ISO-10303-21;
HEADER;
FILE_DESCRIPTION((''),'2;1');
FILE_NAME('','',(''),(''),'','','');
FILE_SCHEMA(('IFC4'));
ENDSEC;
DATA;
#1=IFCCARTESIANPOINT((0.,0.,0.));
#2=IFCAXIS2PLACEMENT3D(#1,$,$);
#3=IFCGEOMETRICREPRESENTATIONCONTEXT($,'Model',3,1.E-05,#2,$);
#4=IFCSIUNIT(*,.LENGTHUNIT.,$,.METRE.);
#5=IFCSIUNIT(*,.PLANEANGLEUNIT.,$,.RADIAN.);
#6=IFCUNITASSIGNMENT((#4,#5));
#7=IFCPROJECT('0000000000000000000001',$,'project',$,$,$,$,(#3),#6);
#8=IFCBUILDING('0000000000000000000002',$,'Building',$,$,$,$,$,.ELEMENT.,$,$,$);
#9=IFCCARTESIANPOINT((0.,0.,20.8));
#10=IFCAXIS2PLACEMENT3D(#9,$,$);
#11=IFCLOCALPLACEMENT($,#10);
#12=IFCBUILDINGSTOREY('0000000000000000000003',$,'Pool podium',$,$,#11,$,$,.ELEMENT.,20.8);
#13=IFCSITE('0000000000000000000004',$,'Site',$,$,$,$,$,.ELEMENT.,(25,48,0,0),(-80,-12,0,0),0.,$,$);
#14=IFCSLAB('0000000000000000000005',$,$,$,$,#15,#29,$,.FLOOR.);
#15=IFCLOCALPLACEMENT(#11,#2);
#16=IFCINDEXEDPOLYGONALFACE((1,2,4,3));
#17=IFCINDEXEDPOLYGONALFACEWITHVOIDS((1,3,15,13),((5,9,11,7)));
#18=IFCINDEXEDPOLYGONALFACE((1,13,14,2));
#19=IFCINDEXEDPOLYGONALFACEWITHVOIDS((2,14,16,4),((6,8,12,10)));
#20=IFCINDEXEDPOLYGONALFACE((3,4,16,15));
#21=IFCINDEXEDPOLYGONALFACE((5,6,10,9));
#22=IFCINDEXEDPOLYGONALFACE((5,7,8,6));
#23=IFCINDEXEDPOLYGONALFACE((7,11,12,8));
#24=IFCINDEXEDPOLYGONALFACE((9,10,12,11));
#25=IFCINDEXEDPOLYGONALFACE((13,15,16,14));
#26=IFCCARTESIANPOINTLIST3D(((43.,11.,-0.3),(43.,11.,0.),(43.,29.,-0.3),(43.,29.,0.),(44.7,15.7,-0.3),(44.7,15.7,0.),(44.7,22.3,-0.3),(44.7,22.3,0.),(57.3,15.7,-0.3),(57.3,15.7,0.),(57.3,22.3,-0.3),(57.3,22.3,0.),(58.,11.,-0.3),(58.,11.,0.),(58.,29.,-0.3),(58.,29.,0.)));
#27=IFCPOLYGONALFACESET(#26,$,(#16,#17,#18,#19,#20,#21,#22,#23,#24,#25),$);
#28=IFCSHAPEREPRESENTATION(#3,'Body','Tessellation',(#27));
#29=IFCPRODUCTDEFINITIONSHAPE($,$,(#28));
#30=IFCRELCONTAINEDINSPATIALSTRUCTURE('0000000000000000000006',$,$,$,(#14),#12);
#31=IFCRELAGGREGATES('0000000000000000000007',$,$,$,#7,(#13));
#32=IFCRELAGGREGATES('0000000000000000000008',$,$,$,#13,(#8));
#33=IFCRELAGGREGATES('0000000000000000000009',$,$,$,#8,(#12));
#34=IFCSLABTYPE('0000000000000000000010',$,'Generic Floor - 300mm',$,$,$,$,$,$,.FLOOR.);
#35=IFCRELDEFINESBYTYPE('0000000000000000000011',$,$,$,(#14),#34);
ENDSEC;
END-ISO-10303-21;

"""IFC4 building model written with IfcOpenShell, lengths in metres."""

from ifc_helpers import new_model, si_unit, frame, origin, place, context, project, spatial, polyline, outline, extrude, type_object, element, save


model = new_model("IFC4")

# Units and contexts
model_context = context("Model", 3, precision=1e-05, world=origin())
ifc_project = project(units=[si_unit("LENGTHUNIT", "METRE"), si_unit("PLANEANGLEUNIT", "RADIAN")], contexts=[model_context])

# Site, building, storey
site = spatial("IfcSite", under=ifc_project, Name="Site", CompositionType="ELEMENT", RefLatitude=(25, 48, 0, 0), RefLongitude=(-80, -12, 0, 0), RefElevation=0.0)
building = spatial("IfcBuilding", under=site, Name="Building", CompositionType="ELEMENT")
storey_placement = place(None, frame((0.0, 0.0, 20.8)))
storey = spatial("IfcBuildingStorey", under=building, at=storey_placement, Name="Pool podium", CompositionType="ELEMENT", Elevation=20.8)

# Slab, opening
slab_type = type_object("IfcSlabType", Name="Generic Floor - 300mm", PredefinedType="FLOOR")
slab_placement = place(None, frame((0.0, 0.0, 20.8)))
slab = element("IfcSlab", 1, at=slab_placement, inside=storey, type_object=slab_type, PredefinedType="FLOOR", context=model_context, shape_type="SweptSolid", body=[
    extrude(outline(polyline([(43.0, 11.0), (58.0, 11.0), (58.0, 29.0), (43.0, 29.0), (43.0, 11.0)])), origin(), (0.0, 0.0, -1.0), 0.3),
])
opening_placement = place(None, frame((0.0, 0.0, 20.801)))
element("IfcOpeningElement", 2, at=opening_placement, cuts=slab, PredefinedType="OPENING", context=model_context, shape_type="SweptSolid", body=[
    extrude(outline(polyline([(44.7, 22.3), (44.7, 15.7), (57.3, 15.7), (57.3, 22.3), (44.7, 22.3)])), origin(), (0.0, 0.0, -1.0), 0.302),
])

save(model, "model.ifc")
